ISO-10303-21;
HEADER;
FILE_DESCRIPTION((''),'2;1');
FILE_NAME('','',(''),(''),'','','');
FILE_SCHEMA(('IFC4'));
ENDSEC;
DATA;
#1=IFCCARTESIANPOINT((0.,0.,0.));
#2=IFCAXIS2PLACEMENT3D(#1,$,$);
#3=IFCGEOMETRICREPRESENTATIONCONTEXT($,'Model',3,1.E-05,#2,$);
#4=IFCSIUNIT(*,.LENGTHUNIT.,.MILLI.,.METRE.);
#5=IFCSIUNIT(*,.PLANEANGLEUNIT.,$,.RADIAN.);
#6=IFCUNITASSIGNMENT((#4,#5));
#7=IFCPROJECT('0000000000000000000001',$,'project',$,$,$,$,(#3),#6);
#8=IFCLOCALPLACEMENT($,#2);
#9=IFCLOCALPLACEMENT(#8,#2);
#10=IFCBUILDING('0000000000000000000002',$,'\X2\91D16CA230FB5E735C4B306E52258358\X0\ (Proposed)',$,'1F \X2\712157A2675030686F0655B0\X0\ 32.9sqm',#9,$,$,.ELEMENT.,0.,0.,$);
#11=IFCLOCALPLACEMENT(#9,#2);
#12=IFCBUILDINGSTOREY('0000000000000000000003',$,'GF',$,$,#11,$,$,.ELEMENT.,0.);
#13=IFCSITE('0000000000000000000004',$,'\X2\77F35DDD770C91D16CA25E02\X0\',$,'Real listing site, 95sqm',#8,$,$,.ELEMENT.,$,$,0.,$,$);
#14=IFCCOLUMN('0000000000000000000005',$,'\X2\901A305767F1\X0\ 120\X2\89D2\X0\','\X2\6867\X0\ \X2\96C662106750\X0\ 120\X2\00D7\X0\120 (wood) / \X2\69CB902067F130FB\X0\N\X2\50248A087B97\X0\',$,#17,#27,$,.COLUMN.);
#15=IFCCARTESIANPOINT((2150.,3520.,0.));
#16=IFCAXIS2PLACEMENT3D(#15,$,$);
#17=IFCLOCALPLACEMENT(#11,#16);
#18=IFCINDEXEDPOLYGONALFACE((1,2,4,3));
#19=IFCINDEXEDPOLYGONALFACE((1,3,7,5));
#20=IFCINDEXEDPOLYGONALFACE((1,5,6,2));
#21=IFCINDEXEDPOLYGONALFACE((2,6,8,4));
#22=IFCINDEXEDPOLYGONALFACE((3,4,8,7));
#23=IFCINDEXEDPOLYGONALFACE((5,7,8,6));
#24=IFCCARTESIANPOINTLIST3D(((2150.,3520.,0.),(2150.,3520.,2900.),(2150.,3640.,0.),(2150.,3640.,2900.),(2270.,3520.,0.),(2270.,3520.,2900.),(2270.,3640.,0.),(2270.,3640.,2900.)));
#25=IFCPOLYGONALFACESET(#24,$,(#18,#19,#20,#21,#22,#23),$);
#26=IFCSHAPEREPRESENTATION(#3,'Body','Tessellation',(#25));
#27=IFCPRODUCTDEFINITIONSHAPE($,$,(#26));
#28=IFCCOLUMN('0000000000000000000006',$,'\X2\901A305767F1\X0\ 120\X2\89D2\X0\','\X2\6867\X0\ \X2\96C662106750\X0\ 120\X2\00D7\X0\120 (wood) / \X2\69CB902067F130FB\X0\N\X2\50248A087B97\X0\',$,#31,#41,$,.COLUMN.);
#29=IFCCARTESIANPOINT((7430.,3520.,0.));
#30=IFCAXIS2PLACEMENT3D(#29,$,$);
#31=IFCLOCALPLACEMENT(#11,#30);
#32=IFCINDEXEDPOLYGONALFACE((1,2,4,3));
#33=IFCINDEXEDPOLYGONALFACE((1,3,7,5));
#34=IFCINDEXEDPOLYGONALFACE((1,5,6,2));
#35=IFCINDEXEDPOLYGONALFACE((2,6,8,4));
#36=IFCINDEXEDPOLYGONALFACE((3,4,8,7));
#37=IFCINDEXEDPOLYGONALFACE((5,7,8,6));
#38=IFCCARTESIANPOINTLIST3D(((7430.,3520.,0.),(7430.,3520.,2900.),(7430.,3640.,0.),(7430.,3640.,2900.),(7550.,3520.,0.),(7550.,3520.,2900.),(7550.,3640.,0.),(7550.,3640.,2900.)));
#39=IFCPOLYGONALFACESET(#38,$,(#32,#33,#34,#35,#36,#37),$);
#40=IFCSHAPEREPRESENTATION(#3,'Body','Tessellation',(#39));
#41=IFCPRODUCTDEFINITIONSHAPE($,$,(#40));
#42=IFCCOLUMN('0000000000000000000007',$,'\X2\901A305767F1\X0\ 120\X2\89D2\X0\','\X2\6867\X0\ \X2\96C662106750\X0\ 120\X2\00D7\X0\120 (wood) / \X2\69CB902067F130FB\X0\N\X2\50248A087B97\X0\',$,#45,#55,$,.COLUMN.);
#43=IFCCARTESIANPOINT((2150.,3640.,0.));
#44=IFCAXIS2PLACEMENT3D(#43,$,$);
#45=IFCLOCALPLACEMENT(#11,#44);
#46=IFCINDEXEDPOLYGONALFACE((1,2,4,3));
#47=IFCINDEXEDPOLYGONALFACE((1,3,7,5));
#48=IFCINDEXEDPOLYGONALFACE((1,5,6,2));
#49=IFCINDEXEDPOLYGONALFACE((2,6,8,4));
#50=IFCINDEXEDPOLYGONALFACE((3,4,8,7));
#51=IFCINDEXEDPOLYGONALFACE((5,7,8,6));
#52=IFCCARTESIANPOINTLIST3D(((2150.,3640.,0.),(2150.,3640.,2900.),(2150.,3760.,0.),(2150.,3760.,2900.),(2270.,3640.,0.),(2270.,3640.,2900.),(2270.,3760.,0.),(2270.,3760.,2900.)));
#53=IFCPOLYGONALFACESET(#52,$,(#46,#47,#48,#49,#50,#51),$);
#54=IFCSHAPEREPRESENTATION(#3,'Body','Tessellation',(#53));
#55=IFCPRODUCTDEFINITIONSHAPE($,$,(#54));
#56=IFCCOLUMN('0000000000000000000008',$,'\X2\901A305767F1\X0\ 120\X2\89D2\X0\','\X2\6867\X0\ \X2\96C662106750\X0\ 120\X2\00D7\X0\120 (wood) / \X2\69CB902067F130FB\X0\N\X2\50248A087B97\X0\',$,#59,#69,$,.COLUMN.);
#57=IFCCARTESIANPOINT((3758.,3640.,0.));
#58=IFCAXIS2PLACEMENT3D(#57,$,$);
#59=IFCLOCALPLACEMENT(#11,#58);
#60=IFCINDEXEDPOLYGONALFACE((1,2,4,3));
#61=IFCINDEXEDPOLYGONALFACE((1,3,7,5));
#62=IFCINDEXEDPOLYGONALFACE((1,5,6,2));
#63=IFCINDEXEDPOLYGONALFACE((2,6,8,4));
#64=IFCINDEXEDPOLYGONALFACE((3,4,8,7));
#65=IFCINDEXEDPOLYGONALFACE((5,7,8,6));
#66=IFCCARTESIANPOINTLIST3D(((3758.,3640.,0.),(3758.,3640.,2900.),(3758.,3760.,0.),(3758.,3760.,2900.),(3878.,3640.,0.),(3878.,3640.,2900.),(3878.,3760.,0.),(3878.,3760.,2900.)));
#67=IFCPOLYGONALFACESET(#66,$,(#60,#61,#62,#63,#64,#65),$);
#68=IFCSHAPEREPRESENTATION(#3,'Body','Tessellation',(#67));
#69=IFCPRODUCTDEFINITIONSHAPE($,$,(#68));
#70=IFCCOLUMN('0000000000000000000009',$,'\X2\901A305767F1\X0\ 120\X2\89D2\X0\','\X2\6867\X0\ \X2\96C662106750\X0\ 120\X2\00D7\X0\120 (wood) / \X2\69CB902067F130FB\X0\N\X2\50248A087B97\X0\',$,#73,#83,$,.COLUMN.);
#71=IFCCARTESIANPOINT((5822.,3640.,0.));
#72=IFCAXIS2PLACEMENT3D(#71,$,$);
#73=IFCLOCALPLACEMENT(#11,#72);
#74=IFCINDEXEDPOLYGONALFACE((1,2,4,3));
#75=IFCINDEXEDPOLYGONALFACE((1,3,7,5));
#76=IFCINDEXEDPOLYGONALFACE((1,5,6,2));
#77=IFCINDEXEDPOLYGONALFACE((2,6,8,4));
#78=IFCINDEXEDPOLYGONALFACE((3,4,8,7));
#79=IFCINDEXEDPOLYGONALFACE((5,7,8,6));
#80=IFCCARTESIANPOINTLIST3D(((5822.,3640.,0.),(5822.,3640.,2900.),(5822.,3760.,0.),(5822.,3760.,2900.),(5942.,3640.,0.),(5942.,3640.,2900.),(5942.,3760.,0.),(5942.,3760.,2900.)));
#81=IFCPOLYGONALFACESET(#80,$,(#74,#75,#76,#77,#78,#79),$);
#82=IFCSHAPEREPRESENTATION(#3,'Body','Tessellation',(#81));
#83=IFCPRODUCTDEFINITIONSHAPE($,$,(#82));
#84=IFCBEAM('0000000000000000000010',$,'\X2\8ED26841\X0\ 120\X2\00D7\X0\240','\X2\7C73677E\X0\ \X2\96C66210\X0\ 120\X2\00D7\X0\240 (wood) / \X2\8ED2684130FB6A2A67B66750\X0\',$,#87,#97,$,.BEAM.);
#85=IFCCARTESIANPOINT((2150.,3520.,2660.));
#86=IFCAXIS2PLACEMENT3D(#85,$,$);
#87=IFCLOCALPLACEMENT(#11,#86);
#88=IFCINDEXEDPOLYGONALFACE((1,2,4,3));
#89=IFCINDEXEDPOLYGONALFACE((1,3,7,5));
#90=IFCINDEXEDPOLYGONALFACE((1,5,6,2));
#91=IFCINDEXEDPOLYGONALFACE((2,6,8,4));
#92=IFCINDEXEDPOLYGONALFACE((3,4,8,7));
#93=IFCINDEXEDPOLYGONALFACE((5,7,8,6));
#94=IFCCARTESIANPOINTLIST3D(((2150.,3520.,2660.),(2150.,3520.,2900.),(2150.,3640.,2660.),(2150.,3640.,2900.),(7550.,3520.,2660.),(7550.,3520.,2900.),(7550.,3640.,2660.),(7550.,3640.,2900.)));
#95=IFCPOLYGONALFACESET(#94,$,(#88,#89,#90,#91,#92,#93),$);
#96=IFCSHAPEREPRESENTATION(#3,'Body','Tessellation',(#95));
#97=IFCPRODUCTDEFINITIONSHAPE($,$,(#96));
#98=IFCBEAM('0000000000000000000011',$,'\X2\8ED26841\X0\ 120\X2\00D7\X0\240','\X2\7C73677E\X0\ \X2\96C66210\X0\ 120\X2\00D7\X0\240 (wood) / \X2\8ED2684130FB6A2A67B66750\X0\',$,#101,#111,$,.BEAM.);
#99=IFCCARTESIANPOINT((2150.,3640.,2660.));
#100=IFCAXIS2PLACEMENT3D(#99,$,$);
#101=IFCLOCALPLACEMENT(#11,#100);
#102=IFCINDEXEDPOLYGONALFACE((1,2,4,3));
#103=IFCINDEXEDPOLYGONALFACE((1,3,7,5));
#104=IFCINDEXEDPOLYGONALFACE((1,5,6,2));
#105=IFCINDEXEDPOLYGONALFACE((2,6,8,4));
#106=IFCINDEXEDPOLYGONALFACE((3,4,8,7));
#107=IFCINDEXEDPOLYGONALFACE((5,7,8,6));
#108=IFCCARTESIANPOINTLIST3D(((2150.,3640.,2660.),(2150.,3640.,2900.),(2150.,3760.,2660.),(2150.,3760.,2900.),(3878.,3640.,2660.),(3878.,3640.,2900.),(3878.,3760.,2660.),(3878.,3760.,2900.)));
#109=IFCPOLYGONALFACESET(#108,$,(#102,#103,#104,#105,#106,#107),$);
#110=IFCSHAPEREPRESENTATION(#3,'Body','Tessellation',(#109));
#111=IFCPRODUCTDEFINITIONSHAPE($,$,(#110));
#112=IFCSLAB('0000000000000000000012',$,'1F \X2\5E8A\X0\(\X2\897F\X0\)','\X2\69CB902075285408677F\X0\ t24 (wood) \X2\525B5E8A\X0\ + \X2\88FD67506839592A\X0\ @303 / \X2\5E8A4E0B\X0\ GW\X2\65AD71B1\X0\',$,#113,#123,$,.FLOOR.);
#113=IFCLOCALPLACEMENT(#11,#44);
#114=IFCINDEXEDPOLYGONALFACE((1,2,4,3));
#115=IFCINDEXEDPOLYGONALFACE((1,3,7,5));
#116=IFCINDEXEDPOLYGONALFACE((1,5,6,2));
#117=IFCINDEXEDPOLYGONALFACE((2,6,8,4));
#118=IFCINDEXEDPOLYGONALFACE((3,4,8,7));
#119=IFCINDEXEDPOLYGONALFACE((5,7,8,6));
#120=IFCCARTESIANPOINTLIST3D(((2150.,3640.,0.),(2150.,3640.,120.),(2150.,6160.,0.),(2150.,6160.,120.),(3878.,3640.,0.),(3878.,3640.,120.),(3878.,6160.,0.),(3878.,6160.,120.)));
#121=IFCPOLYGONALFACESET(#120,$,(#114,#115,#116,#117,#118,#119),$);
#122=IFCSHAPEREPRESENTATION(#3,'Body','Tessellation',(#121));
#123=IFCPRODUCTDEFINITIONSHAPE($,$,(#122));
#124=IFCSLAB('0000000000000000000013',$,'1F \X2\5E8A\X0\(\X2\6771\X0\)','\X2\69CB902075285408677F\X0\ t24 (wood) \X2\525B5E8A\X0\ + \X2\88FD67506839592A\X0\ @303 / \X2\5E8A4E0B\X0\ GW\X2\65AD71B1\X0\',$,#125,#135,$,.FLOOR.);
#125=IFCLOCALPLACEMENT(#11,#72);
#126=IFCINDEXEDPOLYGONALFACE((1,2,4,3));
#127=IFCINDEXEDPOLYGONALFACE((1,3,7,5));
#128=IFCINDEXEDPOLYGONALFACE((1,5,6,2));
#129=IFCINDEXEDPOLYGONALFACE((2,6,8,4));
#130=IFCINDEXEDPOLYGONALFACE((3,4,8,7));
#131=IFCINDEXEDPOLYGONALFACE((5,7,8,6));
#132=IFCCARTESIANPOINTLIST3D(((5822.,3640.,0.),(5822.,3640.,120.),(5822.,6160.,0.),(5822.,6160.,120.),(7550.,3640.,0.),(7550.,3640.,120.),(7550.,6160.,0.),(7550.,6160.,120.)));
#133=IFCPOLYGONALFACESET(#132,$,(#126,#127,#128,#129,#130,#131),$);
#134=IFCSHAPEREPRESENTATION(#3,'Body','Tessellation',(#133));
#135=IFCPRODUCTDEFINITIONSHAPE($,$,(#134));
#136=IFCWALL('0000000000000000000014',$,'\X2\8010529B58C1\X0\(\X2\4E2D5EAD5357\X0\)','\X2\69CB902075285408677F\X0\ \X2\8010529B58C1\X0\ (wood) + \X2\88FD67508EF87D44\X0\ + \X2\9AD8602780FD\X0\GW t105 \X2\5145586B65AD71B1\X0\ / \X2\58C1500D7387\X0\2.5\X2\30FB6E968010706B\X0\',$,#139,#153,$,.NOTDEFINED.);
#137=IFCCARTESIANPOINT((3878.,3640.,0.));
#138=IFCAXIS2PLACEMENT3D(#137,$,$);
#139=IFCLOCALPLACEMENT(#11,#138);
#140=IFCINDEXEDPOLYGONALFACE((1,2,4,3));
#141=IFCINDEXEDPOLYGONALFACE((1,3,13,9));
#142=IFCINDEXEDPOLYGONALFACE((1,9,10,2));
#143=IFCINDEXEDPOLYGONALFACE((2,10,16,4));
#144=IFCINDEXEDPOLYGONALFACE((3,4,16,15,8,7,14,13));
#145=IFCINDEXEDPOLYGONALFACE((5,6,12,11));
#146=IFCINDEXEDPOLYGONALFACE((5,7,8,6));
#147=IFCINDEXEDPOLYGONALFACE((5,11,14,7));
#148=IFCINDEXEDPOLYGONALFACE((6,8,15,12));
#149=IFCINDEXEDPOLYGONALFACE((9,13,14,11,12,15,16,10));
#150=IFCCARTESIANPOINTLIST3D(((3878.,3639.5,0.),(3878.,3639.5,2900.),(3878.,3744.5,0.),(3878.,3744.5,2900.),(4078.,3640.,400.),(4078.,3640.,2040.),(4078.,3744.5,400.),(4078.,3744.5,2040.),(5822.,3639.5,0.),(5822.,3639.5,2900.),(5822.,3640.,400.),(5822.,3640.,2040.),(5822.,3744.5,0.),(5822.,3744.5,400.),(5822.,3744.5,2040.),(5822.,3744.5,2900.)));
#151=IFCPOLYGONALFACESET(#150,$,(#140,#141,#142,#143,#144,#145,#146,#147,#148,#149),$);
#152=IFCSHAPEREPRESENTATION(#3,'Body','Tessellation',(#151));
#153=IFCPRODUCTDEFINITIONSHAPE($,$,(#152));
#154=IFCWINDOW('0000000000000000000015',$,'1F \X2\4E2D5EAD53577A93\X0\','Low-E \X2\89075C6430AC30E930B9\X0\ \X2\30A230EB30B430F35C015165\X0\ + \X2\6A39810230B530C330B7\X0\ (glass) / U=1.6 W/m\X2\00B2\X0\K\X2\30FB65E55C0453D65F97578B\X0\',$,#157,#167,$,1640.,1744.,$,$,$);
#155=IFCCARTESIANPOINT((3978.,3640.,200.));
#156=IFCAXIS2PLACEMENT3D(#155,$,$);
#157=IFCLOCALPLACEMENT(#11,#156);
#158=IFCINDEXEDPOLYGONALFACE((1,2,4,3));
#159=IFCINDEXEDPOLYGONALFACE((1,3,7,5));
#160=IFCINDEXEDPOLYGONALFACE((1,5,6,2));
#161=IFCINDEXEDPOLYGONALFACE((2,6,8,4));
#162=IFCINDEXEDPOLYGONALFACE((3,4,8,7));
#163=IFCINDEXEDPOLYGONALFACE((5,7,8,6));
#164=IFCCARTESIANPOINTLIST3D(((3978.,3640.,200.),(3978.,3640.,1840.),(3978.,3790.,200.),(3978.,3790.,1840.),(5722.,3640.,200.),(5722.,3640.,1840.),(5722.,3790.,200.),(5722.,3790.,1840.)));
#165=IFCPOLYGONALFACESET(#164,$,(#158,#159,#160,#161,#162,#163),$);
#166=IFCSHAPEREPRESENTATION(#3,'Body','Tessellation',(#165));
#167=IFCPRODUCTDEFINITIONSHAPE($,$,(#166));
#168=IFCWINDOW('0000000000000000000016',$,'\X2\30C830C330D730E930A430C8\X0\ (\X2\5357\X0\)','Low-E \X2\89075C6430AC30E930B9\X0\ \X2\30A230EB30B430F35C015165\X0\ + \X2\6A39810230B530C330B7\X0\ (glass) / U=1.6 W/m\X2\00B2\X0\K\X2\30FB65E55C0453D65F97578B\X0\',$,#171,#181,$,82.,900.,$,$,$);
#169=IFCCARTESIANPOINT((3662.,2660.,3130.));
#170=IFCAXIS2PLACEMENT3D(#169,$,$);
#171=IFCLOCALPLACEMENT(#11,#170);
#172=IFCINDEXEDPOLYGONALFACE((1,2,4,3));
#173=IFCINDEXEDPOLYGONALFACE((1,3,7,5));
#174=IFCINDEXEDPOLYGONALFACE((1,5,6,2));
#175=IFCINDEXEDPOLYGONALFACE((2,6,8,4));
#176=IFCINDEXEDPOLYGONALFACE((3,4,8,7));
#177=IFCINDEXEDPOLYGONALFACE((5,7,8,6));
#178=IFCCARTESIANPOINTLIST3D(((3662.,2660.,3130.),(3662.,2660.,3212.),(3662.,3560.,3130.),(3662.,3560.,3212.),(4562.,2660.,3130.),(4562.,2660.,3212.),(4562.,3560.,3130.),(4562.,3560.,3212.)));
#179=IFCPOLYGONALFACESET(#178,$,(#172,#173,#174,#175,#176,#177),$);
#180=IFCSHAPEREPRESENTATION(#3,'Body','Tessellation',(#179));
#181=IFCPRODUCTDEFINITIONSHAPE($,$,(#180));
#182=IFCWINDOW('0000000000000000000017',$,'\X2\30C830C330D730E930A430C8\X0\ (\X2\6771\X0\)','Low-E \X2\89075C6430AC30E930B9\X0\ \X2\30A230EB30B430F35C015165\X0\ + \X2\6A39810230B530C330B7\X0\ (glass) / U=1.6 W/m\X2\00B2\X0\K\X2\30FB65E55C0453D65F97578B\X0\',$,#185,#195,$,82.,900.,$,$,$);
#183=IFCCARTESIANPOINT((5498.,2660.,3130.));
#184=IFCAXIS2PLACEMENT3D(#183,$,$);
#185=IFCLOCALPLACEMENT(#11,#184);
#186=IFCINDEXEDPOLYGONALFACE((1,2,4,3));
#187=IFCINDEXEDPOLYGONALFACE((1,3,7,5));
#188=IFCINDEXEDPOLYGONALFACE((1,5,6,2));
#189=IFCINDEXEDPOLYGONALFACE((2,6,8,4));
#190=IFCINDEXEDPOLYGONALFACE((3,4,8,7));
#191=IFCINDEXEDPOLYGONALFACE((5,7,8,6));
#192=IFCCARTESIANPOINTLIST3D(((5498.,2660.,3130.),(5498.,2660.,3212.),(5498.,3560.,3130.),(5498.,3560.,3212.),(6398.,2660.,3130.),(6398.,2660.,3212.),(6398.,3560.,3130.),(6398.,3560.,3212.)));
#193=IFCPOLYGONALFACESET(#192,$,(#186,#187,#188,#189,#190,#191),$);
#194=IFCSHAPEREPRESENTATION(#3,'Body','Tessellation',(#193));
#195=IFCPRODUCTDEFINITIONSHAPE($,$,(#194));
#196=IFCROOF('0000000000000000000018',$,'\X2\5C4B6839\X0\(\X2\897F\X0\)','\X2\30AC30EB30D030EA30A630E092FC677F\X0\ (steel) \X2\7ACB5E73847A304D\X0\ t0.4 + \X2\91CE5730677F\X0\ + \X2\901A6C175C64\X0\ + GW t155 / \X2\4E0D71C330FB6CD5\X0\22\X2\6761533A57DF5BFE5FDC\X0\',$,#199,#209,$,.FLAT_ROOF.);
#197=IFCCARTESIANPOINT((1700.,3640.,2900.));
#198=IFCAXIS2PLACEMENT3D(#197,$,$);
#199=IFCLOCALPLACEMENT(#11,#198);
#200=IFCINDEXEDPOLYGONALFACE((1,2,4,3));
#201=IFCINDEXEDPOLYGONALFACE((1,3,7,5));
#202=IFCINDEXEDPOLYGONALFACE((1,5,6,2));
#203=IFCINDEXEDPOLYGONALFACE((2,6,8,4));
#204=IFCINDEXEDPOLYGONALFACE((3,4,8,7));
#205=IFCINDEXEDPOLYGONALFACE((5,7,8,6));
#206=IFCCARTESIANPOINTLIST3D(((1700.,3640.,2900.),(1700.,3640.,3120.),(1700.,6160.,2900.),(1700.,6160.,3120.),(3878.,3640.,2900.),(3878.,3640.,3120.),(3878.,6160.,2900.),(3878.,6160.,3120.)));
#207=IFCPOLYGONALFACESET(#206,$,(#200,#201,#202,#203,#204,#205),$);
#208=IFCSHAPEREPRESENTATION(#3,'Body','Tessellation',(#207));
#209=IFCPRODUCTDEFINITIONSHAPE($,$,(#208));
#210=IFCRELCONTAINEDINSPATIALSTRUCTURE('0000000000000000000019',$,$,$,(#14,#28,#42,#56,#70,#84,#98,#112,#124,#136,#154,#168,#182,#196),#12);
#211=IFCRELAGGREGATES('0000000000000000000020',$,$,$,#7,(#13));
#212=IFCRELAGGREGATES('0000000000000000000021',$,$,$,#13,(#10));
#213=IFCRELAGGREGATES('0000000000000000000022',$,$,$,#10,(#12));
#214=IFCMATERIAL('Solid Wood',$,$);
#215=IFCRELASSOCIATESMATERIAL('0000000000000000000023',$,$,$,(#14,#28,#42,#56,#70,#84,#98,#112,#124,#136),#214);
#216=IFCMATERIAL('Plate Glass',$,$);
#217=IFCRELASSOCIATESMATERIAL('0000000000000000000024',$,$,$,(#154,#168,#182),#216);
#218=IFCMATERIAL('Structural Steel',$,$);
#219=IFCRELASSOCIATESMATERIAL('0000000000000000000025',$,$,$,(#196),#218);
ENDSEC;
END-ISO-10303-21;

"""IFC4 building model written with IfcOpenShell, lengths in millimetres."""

from ifc_helpers import new_model, si_unit, frame, frame_2d, origin, place, context, project, spatial, rectangle, extrude, material, element, fill, save


model = new_model("IFC4")

# Units and contexts
model_context = context("Model", 3, precision=1e-05, world=origin())
ifc_project = project(units=[si_unit("LENGTHUNIT", "METRE", prefix="MILLI"), si_unit("PLANEANGLEUNIT", "RADIAN")], contexts=[model_context])

# Site, building, storey
site_placement = place(None, origin())
site = spatial("IfcSite", under=ifc_project, at=site_placement, Name="石川県金沢市", ObjectType="Real listing site, 95sqm", CompositionType="ELEMENT", RefElevation=0.0)
building_placement = place(site_placement, origin())
building = spatial("IfcBuilding", under=site, at=building_placement, Name="金沢・平屋の別荘 (Proposed)", ObjectType="1F 無垢材と漆喰 32.9sqm", CompositionType="ELEMENT", ElevationOfRefHeight=0.0, ElevationOfTerrain=0.0)
storey_placement = place(building_placement, origin())
storey = spatial("IfcBuildingStorey", under=building, at=storey_placement, Name="GF", CompositionType="ELEMENT", Elevation=0.0)

# Columns
ifc_material_1 = material(Name="Solid Wood")
column_1_placement = place(storey_placement, frame((2150.0, 3520.0, 0.0)))
element("IfcColumn", 1, at=column_1_placement, inside=storey, material=ifc_material_1, Name="通し柱 120角", Description="桧 集成材 120×120 (wood) / 構造柱・N値計算", PredefinedType="COLUMN", context=model_context, shape_type="SweptSolid", body=[
    extrude(rectangle(XDim=120.0, YDim=120.0, at=frame_2d((60.0, 60.0))), frame((2150.0, 3520.0, 0.0)), (0.0, 0.0, 1.0), 2900.0),
])
column_2_placement = place(storey_placement, frame((7430.0, 3520.0, 0.0)))
element("IfcColumn", 2, at=column_2_placement, inside=storey, material=ifc_material_1, Name="通し柱 120角", Description="桧 集成材 120×120 (wood) / 構造柱・N値計算", PredefinedType="COLUMN", context=model_context, shape_type="SweptSolid", body=[
    extrude(rectangle(XDim=120.0, YDim=120.0, at=frame_2d((60.0, 60.0))), frame((7430.0, 3520.0, 0.0)), (0.0, 0.0, 1.0), 2900.0),
])
column_3_placement = place(storey_placement, frame((2150.0, 3640.0, 0.0)))
element("IfcColumn", 3, at=column_3_placement, inside=storey, material=ifc_material_1, Name="通し柱 120角", Description="桧 集成材 120×120 (wood) / 構造柱・N値計算", PredefinedType="COLUMN", context=model_context, shape_type="SweptSolid", body=[
    extrude(rectangle(XDim=120.0, YDim=120.0, at=frame_2d((60.0, 60.0))), frame((2150.0, 3640.0, 0.0)), (0.0, 0.0, 1.0), 2900.0),
])
column_4_placement = place(storey_placement, frame((3758.0, 3640.0, 0.0)))
element("IfcColumn", 4, at=column_4_placement, inside=storey, material=ifc_material_1, Name="通し柱 120角", Description="桧 集成材 120×120 (wood) / 構造柱・N値計算", PredefinedType="COLUMN", context=model_context, shape_type="SweptSolid", body=[
    extrude(rectangle(XDim=120.0, YDim=120.0, at=frame_2d((60.0, 60.0))), frame((3758.0, 3640.0, 0.0)), (0.0, 0.0, 1.0), 2900.0),
])
column_5_placement = place(storey_placement, frame((5822.0, 3640.0, 0.0)))
element("IfcColumn", 5, at=column_5_placement, inside=storey, material=ifc_material_1, Name="通し柱 120角", Description="桧 集成材 120×120 (wood) / 構造柱・N値計算", PredefinedType="COLUMN", context=model_context, shape_type="SweptSolid", body=[
    extrude(rectangle(XDim=120.0, YDim=120.0, at=frame_2d((60.0, 60.0))), frame((5822.0, 3640.0, 0.0)), (0.0, 0.0, 1.0), 2900.0),
])

# Beams
beam_1_placement = place(storey_placement, frame((2150.0, 3520.0, 2660.0)))
element("IfcBeam", 6, at=beam_1_placement, inside=storey, material=ifc_material_1, Name="軒桁 120×240", Description="米松 集成 120×240 (wood) / 軒桁・横架材", PredefinedType="BEAM", context=model_context, shape_type="SweptSolid", body=[
    extrude(rectangle(XDim=5400.0, YDim=120.0, at=frame_2d((2700.0, 60.0))), frame((2150.0, 3520.0, 2660.0)), (0.0, 0.0, 1.0), 240.0),
])
beam_2_placement = place(storey_placement, frame((2150.0, 3640.0, 2660.0)))
element("IfcBeam", 7, at=beam_2_placement, inside=storey, material=ifc_material_1, Name="軒桁 120×240", Description="米松 集成 120×240 (wood) / 軒桁・横架材", PredefinedType="BEAM", context=model_context, shape_type="SweptSolid", body=[
    extrude(rectangle(XDim=1728.0, YDim=120.0, at=frame_2d((864.0, 60.0))), frame((2150.0, 3640.0, 2660.0)), (0.0, 0.0, 1.0), 240.0),
])

# Slabs
slab_1_placement = place(storey_placement, frame((2150.0, 3640.0, 0.0)))
element("IfcSlab", 8, at=slab_1_placement, inside=storey, material=ifc_material_1, Name="1F 床(西)", Description="構造用合板 t24 (wood) 剛床 + 製材根太 @303 / 床下 GW断熱", PredefinedType="FLOOR", context=model_context, shape_type="SweptSolid", body=[
    extrude(rectangle(XDim=1728.0, YDim=2520.0, at=frame_2d((864.0, 1260.0))), frame((2150.0, 3640.0, 0.0)), (0.0, 0.0, 1.0), 120.0),
])
slab_2_placement = place(storey_placement, frame((5822.0, 3640.0, 0.0)))
element("IfcSlab", 9, at=slab_2_placement, inside=storey, material=ifc_material_1, Name="1F 床(東)", Description="構造用合板 t24 (wood) 剛床 + 製材根太 @303 / 床下 GW断熱", PredefinedType="FLOOR", context=model_context, shape_type="SweptSolid", body=[
    extrude(rectangle(XDim=1728.0, YDim=2520.0, at=frame_2d((864.0, 1260.0))), frame((5822.0, 3640.0, 0.0)), (0.0, 0.0, 1.0), 120.0),
])

# Wall, opening, window
wall_1_placement = place(storey_placement, frame((3878.0, 3640.0, 0.0)))
wall_1 = element("IfcWall", 10, at=wall_1_placement, inside=storey, material=ifc_material_1, Name="耐力壁(中庭南)", Description="構造用合板 耐力壁 (wood) + 製材軸組 + 高性能GW t105 充填断熱 / 壁倍率2.5・準耐火", PredefinedType="NOTDEFINED", context=model_context, shape_type="SweptSolid", body=[
    extrude(rectangle(XDim=1944.0, YDim=105.0, at=frame_2d((972.0, 52.0))), frame((3878.0, 3640.0, 0.0)), (0.0, 0.0, 1.0), 2900.0),
])
opening_placement = place(storey_placement, frame((3978.0, 3640.0, 200.0)))
opening = element("IfcOpeningElement", 11, at=opening_placement, cuts=wall_1, PredefinedType="NOTDEFINED", context=model_context, shape_type="SweptSolid", body=[
    extrude(rectangle(XDim=1744.0, YDim=150.0, at=frame_2d((872.0, 75.0))), frame((3978.0, 3640.0, 200.0)), (0.0, 0.0, 1.0), 1640.0),
])
ifc_material_2 = material(Name="Plate Glass")
window_1_placement = place(storey_placement, frame((3978.0, 3640.0, 200.0)))
window_1 = element("IfcWindow", 12, at=window_1_placement, inside=storey, material=ifc_material_2, Name="1F 中庭南窓", Description="Low-E 複層ガラス アルゴン封入 + 樹脂サッシ (glass) / U=1.6 W/m²K・日射取得型", OverallHeight=1640.0, OverallWidth=1744.0, context=model_context, shape_type="SweptSolid", body=[
    extrude(rectangle(XDim=1744.0, YDim=150.0, at=frame_2d((872.0, 75.0))), frame((3978.0, 3640.0, 200.0)), (0.0, 0.0, 1.0), 1640.0),
])
fill(opening, window_1)

# Windows
window_2_placement = place(storey_placement, frame((3662.0, 2660.0, 3130.0)))
element("IfcWindow", 13, at=window_2_placement, inside=storey, material=ifc_material_2, Name="トップライト (南)", Description="Low-E 複層ガラス アルゴン封入 + 樹脂サッシ (glass) / U=1.6 W/m²K・日射取得型", OverallHeight=82.0, OverallWidth=900.0, context=model_context, shape_type="SweptSolid", body=[
    extrude(rectangle(XDim=900.0, YDim=900.0, at=frame_2d((450.0, 450.0))), frame((3662.0, 2660.0, 3130.0)), (0.0, 0.0, 1.0), 82.0),
])
window_3_placement = place(storey_placement, frame((5498.0, 2660.0, 3130.0)))
element("IfcWindow", 14, at=window_3_placement, inside=storey, material=ifc_material_2, Name="トップライト (東)", Description="Low-E 複層ガラス アルゴン封入 + 樹脂サッシ (glass) / U=1.6 W/m²K・日射取得型", OverallHeight=82.0, OverallWidth=900.0, context=model_context, shape_type="SweptSolid", body=[
    extrude(rectangle(XDim=900.0, YDim=900.0, at=frame_2d((450.0, 450.0))), frame((5498.0, 2660.0, 3130.0)), (0.0, 0.0, 1.0), 82.0),
])

# Roof
ifc_material_3 = material(Name="Structural Steel")
roof_1_placement = place(storey_placement, frame((1700.0, 3640.0, 2900.0)))
element("IfcRoof", 15, at=roof_1_placement, inside=storey, material=ifc_material_3, Name="屋根(西)", Description="ガルバリウム鋼板 (steel) 立平葺き t0.4 + 野地板 + 通気層 + GW t155 / 不燃・法22条区域対応", PredefinedType="FLAT_ROOF", context=model_context, shape_type="SweptSolid", body=[
    extrude(rectangle(XDim=2178.0, YDim=2520.0, at=frame_2d((1089.0, 1260.0))), frame((1700.0, 3640.0, 2900.0)), (0.0, 0.0, 1.0), 220.0),
])

save(model, "model.ifc")
